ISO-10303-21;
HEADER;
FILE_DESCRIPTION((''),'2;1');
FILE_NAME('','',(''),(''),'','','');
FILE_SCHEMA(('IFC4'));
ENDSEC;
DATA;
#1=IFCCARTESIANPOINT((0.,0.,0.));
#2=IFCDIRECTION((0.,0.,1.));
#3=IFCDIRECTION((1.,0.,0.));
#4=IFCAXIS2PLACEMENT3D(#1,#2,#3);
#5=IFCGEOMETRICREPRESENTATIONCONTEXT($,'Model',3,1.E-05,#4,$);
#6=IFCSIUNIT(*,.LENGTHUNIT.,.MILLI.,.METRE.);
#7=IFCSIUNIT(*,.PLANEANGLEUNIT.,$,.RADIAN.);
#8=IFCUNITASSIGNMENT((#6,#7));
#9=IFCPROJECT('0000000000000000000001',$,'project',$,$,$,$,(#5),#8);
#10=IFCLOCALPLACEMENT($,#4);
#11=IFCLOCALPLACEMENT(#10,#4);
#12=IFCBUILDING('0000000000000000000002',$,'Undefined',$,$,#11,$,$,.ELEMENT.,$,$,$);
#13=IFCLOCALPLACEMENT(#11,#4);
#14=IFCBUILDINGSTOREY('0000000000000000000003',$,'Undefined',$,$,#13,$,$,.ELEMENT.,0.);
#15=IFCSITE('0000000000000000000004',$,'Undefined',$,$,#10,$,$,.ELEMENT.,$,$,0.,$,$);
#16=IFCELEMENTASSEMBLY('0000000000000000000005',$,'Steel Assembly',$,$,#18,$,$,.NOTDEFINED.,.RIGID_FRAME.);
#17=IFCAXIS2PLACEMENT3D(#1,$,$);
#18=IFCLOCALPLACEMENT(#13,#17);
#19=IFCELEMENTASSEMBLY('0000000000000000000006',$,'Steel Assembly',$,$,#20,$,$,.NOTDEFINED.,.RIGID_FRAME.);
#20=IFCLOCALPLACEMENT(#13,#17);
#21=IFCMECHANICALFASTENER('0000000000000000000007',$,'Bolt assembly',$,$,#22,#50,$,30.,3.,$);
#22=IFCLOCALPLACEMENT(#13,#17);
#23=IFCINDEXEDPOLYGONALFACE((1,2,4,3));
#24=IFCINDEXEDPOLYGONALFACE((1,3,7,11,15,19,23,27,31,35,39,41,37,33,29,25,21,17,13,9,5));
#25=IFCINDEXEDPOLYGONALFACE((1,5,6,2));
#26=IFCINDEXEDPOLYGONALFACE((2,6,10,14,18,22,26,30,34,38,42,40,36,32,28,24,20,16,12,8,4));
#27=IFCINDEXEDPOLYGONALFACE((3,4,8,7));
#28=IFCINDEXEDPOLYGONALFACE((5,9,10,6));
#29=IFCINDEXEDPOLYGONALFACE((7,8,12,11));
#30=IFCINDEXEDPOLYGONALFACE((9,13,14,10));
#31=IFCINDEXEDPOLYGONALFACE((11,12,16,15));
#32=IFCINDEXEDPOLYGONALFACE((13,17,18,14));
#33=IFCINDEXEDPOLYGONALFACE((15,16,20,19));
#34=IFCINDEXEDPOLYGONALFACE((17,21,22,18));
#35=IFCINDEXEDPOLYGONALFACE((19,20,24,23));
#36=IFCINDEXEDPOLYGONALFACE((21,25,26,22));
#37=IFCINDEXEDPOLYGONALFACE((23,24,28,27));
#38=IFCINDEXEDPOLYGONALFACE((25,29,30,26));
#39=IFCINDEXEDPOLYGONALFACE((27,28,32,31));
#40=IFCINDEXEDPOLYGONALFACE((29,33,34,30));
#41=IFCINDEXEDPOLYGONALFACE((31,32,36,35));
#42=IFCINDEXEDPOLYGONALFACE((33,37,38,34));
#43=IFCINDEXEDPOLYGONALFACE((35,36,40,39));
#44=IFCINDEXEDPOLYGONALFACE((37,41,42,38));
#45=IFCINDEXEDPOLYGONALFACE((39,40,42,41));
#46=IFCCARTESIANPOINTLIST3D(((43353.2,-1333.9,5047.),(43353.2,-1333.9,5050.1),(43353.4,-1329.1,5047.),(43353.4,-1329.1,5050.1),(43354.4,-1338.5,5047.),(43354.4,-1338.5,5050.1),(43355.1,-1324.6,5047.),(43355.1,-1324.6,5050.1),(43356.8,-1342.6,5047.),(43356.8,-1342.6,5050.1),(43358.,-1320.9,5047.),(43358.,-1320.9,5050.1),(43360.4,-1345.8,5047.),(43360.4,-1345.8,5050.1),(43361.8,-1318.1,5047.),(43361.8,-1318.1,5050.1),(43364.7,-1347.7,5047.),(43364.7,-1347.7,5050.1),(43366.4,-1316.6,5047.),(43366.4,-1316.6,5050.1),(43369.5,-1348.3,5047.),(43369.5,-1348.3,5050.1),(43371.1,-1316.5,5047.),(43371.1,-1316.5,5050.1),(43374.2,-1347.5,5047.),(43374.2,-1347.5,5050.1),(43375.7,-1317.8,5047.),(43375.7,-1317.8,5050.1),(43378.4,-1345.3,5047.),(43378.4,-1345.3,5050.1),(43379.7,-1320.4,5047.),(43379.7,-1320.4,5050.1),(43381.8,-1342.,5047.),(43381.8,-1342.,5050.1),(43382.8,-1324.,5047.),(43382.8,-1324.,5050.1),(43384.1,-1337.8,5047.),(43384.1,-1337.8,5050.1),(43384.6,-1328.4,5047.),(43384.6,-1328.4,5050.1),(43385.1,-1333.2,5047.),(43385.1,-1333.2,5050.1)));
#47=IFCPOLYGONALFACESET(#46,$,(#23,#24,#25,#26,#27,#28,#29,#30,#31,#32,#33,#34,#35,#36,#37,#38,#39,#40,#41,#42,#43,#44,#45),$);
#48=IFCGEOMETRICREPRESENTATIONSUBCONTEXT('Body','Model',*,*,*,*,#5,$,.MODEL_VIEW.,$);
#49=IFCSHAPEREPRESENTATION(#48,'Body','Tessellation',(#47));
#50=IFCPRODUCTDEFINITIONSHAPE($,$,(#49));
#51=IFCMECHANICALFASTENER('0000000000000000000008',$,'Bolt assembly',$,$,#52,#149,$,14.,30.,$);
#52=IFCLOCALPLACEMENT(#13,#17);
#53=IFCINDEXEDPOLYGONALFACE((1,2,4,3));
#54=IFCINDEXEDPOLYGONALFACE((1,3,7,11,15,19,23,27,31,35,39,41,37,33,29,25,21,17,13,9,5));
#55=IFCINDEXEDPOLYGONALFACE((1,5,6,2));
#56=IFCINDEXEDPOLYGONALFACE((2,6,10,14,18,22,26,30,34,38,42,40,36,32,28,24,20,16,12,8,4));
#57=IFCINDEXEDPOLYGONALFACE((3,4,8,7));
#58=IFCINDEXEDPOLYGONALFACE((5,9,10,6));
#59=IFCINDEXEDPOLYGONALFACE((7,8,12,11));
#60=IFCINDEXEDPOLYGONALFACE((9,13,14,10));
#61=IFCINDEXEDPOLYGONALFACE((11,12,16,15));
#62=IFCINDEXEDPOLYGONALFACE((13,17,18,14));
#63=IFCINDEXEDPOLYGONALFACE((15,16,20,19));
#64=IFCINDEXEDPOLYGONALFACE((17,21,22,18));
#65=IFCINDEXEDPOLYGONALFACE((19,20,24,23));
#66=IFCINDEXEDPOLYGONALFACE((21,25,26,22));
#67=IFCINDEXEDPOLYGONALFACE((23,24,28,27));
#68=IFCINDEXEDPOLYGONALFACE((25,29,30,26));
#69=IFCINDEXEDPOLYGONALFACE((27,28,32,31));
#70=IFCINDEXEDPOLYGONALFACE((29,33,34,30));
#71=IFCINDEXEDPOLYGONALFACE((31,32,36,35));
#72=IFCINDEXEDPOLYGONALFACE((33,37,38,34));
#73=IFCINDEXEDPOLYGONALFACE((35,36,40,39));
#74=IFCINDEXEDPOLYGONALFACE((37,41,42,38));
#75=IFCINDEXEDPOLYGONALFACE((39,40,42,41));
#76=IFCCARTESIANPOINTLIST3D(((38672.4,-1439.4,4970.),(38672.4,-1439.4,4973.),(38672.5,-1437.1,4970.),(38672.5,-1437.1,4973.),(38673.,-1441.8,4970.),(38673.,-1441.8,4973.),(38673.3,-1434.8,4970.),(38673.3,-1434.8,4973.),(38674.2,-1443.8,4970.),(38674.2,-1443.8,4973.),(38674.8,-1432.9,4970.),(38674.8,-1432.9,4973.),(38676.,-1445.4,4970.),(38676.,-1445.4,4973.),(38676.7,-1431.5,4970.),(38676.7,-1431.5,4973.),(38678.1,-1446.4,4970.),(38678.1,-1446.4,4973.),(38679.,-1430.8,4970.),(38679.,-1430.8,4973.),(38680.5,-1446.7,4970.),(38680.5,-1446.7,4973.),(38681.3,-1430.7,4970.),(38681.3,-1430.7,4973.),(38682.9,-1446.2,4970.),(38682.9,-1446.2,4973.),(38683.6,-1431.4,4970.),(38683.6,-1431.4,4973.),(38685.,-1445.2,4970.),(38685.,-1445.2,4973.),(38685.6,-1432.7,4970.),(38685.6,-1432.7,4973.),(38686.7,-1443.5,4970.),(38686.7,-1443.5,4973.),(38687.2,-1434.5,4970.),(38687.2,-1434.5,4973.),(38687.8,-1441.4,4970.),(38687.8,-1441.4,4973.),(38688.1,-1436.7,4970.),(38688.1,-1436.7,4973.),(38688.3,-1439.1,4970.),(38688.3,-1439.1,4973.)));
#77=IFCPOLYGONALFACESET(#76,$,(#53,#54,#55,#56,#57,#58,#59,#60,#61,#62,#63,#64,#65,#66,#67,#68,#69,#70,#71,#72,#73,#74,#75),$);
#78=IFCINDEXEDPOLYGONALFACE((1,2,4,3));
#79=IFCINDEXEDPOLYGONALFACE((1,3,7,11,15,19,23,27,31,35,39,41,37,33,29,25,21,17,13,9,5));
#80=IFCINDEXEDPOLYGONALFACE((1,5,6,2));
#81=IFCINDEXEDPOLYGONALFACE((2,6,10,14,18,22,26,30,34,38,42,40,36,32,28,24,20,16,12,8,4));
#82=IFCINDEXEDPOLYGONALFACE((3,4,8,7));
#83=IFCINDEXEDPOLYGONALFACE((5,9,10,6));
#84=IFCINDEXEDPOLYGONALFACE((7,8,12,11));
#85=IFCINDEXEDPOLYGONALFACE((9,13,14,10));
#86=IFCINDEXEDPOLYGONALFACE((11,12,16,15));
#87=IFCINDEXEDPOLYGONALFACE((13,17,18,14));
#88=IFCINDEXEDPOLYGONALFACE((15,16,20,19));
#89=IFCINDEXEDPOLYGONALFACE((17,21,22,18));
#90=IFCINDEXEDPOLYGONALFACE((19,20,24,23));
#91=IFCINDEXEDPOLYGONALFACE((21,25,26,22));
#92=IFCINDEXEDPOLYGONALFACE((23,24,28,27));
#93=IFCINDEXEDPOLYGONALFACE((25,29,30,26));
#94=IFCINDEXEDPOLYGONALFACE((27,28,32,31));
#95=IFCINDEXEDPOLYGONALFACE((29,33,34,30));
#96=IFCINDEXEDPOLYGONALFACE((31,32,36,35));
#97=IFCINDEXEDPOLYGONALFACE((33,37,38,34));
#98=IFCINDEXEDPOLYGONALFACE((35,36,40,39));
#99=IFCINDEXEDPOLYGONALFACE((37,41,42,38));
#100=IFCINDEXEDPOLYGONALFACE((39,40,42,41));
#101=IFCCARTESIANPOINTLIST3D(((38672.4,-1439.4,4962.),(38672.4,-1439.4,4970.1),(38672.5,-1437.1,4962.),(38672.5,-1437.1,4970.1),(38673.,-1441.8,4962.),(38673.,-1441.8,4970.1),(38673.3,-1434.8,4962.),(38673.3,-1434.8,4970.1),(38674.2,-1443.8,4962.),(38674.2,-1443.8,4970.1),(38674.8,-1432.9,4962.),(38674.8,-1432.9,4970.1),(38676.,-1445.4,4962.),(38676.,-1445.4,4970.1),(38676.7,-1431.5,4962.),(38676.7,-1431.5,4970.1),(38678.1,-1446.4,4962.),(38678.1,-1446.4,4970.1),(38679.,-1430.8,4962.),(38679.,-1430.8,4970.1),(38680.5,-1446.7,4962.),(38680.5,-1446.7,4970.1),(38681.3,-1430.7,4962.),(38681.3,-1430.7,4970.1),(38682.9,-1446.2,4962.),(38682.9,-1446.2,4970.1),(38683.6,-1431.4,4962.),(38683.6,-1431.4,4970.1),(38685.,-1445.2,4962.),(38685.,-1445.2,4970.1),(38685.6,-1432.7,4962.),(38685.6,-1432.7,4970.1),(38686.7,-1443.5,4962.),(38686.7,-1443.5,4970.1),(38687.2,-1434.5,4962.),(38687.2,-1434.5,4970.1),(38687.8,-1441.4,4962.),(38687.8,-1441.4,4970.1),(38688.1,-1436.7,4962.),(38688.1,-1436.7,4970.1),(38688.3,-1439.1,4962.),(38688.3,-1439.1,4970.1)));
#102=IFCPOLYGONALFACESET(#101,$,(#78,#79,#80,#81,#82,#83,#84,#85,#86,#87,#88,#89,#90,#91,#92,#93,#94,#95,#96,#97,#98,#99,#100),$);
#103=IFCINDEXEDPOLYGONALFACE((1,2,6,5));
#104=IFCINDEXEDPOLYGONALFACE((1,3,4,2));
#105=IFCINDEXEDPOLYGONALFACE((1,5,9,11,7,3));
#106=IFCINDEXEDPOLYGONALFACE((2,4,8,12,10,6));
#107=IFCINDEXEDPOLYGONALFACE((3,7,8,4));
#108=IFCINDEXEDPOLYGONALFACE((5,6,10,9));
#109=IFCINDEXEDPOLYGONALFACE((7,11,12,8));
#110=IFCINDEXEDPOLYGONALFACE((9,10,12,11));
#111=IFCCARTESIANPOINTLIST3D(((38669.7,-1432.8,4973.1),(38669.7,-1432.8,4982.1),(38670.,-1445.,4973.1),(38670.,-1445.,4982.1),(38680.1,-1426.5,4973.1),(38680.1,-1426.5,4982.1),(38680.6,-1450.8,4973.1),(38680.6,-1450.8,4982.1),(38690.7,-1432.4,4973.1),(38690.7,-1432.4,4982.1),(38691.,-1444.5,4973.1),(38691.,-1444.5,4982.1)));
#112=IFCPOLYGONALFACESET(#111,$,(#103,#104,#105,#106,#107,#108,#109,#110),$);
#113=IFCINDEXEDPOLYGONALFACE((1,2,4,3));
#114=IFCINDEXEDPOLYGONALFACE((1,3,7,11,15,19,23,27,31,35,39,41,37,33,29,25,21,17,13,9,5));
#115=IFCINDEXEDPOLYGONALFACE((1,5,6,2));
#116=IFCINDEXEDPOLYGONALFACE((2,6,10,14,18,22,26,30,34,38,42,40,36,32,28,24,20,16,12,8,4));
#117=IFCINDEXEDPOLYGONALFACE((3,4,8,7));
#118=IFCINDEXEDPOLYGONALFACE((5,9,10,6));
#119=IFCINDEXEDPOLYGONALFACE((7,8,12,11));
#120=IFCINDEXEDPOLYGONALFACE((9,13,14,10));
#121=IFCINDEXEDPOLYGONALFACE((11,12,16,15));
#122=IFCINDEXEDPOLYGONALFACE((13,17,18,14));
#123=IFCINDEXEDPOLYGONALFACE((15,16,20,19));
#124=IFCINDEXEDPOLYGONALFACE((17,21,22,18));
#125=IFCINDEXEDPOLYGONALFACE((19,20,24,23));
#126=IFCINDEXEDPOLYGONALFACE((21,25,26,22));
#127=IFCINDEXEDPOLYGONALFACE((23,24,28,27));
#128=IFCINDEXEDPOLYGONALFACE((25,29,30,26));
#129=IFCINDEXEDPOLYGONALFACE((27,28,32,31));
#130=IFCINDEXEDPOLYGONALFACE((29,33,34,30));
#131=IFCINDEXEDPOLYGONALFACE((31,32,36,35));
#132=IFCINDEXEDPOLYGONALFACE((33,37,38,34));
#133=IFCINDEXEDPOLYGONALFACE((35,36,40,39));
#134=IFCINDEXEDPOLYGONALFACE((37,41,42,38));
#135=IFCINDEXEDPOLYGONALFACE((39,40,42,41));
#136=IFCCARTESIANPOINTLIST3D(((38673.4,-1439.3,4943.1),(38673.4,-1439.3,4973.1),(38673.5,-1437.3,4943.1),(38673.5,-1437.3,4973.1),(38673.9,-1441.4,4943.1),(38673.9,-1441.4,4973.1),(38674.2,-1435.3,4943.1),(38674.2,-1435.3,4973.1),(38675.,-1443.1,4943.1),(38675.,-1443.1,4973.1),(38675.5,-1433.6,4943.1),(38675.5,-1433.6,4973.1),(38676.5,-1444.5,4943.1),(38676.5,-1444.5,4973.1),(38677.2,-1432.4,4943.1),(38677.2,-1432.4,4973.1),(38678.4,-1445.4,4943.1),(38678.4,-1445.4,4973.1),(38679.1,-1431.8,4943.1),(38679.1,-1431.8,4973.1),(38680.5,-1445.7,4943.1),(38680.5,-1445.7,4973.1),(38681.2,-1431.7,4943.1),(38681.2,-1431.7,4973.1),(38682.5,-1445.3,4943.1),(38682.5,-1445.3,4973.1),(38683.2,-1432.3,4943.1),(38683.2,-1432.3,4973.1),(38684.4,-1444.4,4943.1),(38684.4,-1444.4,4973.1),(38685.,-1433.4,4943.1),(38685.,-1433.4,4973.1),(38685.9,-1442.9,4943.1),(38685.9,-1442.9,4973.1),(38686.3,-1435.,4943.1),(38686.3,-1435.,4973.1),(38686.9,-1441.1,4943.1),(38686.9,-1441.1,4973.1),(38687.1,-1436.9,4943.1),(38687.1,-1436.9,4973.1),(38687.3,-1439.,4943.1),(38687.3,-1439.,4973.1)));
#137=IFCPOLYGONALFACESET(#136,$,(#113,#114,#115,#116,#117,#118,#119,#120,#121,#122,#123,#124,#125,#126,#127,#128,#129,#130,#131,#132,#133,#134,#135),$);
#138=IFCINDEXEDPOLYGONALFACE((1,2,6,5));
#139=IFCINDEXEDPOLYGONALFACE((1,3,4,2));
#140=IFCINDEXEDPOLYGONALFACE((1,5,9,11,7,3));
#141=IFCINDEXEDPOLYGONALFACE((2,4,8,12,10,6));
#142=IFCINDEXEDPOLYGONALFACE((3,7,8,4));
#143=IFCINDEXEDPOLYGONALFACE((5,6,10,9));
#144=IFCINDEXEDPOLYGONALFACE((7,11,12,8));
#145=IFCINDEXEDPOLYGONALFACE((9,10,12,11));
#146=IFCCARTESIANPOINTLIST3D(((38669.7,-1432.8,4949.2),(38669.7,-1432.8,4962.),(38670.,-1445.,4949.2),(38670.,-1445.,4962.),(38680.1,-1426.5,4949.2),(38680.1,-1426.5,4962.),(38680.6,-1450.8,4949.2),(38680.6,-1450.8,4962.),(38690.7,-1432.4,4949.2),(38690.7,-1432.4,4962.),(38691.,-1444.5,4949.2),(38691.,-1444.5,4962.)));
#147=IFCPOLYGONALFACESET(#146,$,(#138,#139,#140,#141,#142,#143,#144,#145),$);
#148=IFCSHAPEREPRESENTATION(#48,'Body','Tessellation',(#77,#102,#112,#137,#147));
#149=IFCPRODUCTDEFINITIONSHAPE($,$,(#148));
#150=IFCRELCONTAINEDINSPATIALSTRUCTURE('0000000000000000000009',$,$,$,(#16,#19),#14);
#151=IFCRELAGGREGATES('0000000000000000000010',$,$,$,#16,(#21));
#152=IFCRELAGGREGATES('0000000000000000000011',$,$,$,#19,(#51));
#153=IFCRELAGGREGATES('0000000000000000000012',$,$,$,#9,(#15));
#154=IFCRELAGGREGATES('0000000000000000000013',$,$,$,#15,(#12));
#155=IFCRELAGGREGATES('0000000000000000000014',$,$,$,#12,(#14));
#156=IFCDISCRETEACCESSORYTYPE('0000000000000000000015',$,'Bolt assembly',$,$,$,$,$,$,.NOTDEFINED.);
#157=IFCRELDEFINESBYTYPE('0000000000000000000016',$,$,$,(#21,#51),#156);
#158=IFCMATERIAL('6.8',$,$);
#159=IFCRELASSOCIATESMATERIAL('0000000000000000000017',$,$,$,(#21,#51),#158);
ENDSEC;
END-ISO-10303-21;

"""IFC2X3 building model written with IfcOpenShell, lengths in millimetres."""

from ifc_helpers import new_model, si_unit, frame, origin_with_axes, origin_2d_with_axis, place, context, subcontext, project, spatial, polyline, circle, outline, extrude, source, transform, mapped, material, type_object, element, aggregate, save


model = new_model("IFC2X3")

# Units and contexts
model_context = context("Model", 3, precision=1e-05, world=origin_with_axes())
body_context = subcontext(model_context, "Body", "Model", "MODEL_VIEW")
ifc_project = project(units=[si_unit("LENGTHUNIT", "METRE", prefix="MILLI"), si_unit("PLANEANGLEUNIT", "RADIAN")], contexts=[model_context])

# Site, building, storey
site_placement = place(None, origin_with_axes())
site = spatial("IfcSite", under=ifc_project, at=site_placement, Name="Undefined", CompositionType="ELEMENT", RefElevation=0.0)
building_placement = place(site_placement, origin_with_axes())
building = spatial("IfcBuilding", under=site, at=building_placement, Name="Undefined", CompositionType="ELEMENT")
storey_placement = place(building_placement, origin_with_axes())
storey = spatial("IfcBuildingStorey", under=building, at=storey_placement, Name="Undefined", CompositionType="ELEMENT", Elevation=0.0)

# Element assembly
assembly_1_placement = place(storey_placement, origin_with_axes())
assembly_1 = element("IfcElementAssembly", 1, at=assembly_1_placement, inside=storey, Name="Steel Assembly", AssemblyPlace="NOTDEFINED", PredefinedType="RIGID_FRAME")

# Element assembly
assembly_2_placement = place(storey_placement, origin_with_axes())
assembly_2 = element("IfcElementAssembly", 2, at=assembly_2_placement, inside=storey, Name="Steel Assembly", AssemblyPlace="NOTDEFINED", PredefinedType="RIGID_FRAME")

# Mechanical fasteners
ifc_material_1 = material(Name="6.8")
discrete_accessory_type_1 = type_object("IfcDiscreteAccessoryType", Name="Bolt assembly")
shared_shape_1 = source(origin_with_axes(), body_context, "Body", "SweptSolid", [
    extrude(circle(Radius=16.0, at=origin_2d_with_axis()), frame((0.0, -0.1, 0.0), z_axis=(0.0, 1.0, 0.0), x_axis=(1.0, 0.0, 0.0)), (0.0, 0.0, 1.0), 3.1),
])
mechanical_fastener_1_placement = place(assembly_1_placement, frame((43369.1, -1332.3, 5050.0), z_axis=(0.999745, 0.022588, 0.0), x_axis=(0.022588, -0.999745, 0.000001)))
mechanical_fastener_1 = element("IfcMechanicalFastener", 3, at=mechanical_fastener_1_placement, type_object=discrete_accessory_type_1, material=ifc_material_1, Name="Bolt assembly", NominalDiameter=30.0, NominalLength=3.0, context=body_context, shape_type="MappedRepresentation", body=[
    mapped(shared_shape_1, transform((0.0, 0.0, 0.0))),
])
aggregate(assembly_1, [mechanical_fastener_1])
shared_shape_2 = source(origin_with_axes(), body_context, "Body", "SweptSolid", [
    extrude(circle(Radius=8.0, at=origin_2d_with_axis()), frame((0.0, -3.0, 0.0), z_axis=(0.0, 1.0, 0.0), x_axis=(1.0, 0.0, 0.0)), (0.0, 0.0, 1.0), 3.0),
    extrude(circle(Radius=8.0, at=origin_2d_with_axis()), frame((0.0, -0.1, 0.0), z_axis=(0.0, 1.0, 0.0), x_axis=(1.0, 0.0, 0.0)), (0.0, 0.0, 1.0), 8.1),
    extrude(outline(polyline([(12.1, 0.0), (6.1, 10.5), (-6.1, 10.5), (-12.1, 0.0), (-6.1, -10.5), (6.1, -10.5), (12.1, 0.0)])), frame((0.0, -12.1, 0.0), z_axis=(0.0, 1.0, 0.0), x_axis=(1.0, 0.0, 0.0)), (0.0, 0.0, 1.0), 9.0),
    extrude(circle(Radius=7.0, at=origin_2d_with_axis()), frame((0.0, -3.1, 0.0), z_axis=(0.0, 1.0, 0.0), x_axis=(1.0, 0.0, 0.0)), (0.0, 0.0, 1.0), 30.0),
    extrude(outline(polyline([(12.1, 0.0), (6.1, 10.5), (-6.1, 10.5), (-12.1, 0.0), (-6.1, -10.5), (6.1, -10.5), (12.1, 0.0)])), frame((0.0, 8.0, 0.0), z_axis=(0.0, 1.0, 0.0), x_axis=(1.0, 0.0, 0.0)), (0.0, 0.0, 1.0), 12.8),
])
mechanical_fastener_2_placement = place(assembly_2_placement, frame((38680.3, -1438.7, 4970.0), z_axis=(0.999741, 0.022754, 0.0), x_axis=(0.022754, -0.999741, 0.000001)))
mechanical_fastener_2 = element("IfcMechanicalFastener", 4, at=mechanical_fastener_2_placement, type_object=discrete_accessory_type_1, material=ifc_material_1, Name="Bolt assembly", NominalDiameter=14.0, NominalLength=30.0, context=body_context, shape_type="MappedRepresentation", body=[
    mapped(shared_shape_2, transform((0.0, 0.0, 0.0))),
])
aggregate(assembly_2, [mechanical_fastener_2])

save(model, "model.ifc")
